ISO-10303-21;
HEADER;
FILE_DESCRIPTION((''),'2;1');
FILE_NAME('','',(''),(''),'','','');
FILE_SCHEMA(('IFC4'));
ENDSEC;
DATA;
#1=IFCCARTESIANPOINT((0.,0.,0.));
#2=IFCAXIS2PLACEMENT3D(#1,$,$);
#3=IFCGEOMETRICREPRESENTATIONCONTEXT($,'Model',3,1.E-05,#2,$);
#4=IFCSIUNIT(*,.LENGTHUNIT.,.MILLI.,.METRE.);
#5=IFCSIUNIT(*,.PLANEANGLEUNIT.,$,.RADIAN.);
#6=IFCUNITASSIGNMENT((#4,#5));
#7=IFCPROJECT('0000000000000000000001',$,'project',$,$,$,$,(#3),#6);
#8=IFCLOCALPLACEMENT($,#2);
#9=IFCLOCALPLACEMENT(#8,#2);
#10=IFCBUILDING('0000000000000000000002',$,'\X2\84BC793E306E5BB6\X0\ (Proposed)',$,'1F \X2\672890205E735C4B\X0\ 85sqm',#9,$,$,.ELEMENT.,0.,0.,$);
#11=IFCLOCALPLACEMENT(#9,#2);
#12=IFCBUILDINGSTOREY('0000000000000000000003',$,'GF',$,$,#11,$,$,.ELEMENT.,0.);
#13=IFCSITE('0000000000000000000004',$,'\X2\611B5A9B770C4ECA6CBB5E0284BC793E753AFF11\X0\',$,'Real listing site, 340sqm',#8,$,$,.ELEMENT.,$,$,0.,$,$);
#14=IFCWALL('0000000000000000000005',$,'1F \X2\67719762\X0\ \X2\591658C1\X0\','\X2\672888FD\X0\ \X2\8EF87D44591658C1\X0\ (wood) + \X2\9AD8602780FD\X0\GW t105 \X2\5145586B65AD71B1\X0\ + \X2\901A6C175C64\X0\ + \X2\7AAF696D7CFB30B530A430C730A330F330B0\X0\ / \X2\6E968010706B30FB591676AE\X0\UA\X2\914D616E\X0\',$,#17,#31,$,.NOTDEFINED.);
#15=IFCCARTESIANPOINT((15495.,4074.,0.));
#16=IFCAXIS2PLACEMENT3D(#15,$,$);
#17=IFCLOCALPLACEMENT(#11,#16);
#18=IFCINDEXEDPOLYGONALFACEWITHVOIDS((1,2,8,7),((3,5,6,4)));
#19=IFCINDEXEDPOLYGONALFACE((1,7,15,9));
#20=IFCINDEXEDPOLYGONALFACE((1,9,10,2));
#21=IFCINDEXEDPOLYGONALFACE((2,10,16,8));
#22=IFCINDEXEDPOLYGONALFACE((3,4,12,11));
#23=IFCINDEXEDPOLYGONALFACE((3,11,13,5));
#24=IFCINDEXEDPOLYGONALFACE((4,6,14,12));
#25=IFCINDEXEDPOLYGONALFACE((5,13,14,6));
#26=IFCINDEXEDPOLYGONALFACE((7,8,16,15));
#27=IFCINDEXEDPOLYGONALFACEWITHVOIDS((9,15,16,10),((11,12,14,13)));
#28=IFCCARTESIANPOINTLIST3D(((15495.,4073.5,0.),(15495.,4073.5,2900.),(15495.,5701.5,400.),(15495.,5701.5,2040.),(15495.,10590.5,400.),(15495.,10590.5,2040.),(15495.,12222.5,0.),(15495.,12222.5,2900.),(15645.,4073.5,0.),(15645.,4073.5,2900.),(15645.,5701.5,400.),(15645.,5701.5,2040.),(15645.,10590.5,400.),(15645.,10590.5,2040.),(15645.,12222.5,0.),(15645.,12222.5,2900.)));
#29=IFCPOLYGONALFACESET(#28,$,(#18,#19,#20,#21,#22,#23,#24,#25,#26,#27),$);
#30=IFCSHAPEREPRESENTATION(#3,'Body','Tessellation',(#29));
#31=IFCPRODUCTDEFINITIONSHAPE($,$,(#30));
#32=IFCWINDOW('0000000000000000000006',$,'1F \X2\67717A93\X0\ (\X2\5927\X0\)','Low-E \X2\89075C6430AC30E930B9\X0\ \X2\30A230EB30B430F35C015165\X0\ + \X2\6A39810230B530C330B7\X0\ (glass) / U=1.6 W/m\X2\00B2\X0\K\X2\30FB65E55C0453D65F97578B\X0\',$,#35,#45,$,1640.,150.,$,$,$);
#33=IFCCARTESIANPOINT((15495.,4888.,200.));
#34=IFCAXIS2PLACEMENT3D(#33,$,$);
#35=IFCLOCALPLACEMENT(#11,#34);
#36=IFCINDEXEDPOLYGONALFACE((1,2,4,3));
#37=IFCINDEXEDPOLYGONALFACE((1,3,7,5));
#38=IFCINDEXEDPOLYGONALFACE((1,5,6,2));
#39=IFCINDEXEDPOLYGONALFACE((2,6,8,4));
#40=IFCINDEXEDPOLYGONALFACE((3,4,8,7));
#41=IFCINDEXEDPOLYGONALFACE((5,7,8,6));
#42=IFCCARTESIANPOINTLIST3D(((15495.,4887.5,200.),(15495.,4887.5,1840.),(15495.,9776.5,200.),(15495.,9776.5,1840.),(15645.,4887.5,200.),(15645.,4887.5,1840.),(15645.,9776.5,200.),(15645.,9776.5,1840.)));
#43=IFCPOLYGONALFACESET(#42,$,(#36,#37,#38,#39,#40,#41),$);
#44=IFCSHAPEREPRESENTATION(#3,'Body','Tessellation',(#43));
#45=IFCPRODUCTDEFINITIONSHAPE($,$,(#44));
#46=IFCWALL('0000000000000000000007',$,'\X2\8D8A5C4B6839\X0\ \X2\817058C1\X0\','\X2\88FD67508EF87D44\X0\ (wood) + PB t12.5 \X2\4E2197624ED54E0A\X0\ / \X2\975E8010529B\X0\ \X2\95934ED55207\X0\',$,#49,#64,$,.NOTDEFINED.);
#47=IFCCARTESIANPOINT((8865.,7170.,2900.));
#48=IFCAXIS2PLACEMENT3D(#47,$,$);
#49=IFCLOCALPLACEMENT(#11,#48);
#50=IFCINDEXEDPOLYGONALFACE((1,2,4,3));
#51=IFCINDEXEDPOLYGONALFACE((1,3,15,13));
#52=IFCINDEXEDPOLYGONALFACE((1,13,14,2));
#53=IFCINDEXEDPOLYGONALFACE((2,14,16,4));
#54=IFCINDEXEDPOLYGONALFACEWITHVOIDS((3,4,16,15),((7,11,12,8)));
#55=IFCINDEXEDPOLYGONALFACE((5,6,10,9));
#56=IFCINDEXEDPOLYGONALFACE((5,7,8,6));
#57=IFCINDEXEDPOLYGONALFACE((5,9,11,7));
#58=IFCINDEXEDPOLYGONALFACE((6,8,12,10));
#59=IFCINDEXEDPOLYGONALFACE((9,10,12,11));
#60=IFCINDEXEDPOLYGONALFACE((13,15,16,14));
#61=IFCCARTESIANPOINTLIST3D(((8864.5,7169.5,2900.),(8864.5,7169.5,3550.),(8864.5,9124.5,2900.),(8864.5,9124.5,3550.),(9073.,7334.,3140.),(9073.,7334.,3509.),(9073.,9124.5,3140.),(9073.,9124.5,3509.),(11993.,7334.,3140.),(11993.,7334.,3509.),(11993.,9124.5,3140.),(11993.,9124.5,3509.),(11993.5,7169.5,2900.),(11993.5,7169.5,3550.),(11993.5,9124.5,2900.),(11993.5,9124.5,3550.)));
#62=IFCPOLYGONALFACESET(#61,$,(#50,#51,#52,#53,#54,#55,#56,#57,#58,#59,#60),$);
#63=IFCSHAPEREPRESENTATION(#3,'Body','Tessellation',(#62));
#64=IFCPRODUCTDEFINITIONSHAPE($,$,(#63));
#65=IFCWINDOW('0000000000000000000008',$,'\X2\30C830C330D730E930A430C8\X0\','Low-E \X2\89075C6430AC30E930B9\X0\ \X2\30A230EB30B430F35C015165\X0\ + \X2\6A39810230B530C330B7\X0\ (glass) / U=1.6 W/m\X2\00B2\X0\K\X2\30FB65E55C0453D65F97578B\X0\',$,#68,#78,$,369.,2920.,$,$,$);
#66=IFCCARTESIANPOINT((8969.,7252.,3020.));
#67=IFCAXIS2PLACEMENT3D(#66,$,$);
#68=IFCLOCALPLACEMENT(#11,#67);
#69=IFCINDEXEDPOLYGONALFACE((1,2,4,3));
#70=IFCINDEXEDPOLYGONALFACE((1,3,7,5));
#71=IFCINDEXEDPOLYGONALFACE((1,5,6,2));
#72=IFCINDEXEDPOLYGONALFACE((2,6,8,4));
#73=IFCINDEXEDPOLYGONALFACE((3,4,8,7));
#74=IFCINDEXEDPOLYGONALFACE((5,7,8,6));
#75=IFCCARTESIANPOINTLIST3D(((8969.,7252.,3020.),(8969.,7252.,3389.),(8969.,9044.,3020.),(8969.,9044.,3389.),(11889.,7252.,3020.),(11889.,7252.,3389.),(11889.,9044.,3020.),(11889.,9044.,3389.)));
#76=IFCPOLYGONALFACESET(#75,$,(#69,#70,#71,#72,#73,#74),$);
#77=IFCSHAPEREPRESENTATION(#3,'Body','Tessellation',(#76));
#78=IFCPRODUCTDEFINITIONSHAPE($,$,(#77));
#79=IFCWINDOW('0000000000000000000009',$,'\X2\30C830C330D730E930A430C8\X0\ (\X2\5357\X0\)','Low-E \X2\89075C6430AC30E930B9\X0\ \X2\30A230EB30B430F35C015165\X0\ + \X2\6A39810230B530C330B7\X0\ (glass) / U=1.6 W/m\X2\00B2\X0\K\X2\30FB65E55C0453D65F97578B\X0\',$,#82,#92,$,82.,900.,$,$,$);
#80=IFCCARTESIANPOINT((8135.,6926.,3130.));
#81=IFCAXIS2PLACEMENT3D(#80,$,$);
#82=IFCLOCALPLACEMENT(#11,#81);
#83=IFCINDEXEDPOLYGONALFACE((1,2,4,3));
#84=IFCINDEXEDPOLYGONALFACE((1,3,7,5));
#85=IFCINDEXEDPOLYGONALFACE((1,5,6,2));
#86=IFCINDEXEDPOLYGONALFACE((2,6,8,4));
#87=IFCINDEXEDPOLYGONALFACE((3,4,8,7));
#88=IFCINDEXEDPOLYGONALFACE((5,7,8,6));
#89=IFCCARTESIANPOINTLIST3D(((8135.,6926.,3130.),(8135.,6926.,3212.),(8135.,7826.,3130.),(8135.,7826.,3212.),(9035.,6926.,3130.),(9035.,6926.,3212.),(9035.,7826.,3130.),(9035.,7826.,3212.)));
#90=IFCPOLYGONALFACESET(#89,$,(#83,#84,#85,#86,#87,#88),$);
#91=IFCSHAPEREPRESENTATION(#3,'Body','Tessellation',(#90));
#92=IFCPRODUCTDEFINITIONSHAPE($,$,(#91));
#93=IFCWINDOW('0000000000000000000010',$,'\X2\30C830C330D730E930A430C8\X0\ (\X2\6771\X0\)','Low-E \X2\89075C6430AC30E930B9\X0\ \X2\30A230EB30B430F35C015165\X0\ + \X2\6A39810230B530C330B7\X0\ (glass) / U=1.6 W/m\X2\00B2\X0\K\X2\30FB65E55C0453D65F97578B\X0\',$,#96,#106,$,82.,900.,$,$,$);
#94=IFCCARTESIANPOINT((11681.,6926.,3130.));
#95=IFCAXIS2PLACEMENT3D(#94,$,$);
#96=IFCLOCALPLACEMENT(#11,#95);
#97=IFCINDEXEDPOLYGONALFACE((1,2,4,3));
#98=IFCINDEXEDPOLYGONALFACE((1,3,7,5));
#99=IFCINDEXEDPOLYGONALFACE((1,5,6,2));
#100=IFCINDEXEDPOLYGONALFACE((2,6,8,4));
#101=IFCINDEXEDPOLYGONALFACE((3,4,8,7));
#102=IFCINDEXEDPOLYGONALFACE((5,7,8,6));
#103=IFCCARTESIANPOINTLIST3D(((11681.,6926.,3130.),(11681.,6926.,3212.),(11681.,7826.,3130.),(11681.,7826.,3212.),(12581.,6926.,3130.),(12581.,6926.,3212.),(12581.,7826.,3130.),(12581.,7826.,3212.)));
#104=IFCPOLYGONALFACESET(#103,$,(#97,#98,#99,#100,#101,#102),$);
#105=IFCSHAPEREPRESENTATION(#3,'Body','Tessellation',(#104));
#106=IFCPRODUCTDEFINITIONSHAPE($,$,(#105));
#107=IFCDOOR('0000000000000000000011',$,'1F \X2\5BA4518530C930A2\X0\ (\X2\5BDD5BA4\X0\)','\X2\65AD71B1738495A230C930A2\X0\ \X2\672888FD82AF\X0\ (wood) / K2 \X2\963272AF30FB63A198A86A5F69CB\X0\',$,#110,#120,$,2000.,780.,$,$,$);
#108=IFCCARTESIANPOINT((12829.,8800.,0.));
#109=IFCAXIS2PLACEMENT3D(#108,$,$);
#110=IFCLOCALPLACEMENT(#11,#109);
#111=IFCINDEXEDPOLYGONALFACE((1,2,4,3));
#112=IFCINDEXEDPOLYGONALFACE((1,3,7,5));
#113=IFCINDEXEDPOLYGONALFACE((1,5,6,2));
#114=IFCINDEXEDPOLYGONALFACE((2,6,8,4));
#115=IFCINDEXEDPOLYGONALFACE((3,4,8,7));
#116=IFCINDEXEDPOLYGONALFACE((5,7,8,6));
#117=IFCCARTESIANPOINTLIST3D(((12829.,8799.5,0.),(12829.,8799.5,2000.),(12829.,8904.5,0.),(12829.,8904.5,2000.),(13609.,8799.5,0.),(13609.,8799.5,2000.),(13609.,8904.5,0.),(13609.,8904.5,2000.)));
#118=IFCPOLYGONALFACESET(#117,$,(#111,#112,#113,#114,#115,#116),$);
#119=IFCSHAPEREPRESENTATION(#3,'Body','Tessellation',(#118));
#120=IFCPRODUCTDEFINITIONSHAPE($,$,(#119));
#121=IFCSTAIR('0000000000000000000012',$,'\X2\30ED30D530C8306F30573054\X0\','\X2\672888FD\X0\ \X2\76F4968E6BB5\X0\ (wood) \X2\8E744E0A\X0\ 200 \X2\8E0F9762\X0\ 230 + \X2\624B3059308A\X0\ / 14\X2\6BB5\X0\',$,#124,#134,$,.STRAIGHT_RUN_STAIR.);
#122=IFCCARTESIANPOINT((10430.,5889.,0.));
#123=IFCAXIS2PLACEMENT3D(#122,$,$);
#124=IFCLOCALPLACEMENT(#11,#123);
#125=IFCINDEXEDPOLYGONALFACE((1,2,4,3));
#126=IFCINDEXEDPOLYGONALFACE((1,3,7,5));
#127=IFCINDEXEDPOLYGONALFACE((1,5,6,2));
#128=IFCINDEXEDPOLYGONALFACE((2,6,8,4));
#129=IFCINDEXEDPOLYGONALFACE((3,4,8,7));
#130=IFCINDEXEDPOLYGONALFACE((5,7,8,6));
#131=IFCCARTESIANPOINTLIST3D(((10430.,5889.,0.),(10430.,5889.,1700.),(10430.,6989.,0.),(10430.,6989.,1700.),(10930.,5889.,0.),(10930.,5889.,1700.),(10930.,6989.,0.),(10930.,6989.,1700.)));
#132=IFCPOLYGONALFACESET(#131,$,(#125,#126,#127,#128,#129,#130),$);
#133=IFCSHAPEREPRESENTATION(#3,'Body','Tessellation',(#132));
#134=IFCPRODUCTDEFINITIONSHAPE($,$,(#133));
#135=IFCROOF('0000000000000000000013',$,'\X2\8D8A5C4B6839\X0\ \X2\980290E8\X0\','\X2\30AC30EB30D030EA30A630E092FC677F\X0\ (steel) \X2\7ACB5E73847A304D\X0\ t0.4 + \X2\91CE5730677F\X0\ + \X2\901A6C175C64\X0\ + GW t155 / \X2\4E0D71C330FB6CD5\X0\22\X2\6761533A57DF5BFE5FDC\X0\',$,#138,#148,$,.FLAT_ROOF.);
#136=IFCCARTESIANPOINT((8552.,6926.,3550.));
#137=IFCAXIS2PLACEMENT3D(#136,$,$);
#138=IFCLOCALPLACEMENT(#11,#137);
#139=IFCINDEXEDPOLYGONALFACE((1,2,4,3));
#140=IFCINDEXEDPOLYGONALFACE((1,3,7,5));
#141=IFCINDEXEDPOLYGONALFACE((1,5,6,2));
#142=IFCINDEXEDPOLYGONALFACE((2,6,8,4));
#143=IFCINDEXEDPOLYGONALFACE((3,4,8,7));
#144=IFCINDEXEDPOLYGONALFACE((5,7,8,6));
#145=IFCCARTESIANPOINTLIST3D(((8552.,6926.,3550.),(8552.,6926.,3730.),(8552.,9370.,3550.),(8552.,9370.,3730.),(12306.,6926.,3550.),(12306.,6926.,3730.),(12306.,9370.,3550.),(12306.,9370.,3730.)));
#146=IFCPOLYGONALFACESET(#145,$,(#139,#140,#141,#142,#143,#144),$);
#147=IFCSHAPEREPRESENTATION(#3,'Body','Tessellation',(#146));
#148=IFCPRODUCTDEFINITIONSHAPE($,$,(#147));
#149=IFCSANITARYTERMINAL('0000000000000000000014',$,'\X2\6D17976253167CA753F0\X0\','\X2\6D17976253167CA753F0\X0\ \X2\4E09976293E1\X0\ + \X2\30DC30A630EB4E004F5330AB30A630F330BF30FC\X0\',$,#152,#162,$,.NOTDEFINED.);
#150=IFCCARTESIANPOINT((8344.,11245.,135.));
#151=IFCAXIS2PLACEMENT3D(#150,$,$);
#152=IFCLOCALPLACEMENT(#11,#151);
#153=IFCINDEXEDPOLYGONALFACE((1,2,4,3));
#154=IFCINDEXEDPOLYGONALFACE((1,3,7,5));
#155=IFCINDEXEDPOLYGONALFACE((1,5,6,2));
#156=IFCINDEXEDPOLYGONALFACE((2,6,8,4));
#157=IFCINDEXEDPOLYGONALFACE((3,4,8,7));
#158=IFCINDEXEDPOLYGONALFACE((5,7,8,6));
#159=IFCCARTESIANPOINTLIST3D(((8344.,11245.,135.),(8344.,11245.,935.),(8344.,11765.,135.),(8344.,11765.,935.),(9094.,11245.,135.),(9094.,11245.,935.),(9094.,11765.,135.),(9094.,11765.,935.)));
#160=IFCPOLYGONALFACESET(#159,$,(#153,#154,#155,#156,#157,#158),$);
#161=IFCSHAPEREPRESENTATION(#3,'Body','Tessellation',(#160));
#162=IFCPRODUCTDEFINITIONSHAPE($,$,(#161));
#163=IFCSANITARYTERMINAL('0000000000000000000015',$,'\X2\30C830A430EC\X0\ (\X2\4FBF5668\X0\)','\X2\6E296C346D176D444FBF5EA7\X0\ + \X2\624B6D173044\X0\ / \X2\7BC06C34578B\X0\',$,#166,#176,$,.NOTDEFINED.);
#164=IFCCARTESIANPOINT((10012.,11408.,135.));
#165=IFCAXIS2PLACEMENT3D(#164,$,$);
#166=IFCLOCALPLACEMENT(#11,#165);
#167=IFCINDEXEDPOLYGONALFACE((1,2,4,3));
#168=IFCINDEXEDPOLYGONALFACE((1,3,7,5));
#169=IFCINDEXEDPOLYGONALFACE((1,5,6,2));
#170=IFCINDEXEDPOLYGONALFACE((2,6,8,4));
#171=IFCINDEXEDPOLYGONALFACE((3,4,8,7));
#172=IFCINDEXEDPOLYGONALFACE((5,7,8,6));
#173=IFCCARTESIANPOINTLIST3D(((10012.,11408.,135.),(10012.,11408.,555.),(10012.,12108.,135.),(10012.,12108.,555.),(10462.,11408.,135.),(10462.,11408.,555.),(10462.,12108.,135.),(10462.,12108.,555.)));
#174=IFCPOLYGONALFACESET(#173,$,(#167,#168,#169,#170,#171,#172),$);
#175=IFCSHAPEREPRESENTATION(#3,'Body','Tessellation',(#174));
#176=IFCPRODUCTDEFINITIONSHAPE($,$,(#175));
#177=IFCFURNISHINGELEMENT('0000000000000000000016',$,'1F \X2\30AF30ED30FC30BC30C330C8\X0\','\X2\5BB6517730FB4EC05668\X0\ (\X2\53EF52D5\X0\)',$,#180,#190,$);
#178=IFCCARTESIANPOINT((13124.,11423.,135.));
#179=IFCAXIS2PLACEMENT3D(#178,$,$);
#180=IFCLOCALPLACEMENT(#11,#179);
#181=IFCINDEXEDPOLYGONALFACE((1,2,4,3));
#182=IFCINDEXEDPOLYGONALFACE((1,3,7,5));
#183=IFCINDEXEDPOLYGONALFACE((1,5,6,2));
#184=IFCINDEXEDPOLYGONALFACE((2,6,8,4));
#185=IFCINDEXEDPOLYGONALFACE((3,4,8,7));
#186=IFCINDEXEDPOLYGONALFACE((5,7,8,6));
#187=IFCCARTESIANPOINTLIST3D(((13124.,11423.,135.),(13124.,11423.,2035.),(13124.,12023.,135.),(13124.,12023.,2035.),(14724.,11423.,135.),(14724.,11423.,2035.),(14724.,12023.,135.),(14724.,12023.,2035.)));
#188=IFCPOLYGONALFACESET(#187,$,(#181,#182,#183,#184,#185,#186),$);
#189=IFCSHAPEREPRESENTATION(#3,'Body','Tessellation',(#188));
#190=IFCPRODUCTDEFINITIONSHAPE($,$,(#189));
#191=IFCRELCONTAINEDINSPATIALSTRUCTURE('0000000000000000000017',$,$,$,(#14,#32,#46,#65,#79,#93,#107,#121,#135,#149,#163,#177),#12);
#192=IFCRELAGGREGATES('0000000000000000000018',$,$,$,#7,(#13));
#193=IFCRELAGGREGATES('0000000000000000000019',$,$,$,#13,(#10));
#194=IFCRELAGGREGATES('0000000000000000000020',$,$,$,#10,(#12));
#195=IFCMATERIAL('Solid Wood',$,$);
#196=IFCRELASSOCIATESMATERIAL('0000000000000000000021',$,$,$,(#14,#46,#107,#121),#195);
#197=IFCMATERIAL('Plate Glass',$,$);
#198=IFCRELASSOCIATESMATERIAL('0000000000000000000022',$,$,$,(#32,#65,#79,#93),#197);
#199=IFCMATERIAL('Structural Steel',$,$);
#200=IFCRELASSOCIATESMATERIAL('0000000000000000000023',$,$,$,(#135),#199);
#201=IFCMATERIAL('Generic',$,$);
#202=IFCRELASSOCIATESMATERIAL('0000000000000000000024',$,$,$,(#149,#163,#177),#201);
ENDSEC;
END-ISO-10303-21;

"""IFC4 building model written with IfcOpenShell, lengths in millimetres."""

from ifc_helpers import new_model, si_unit, frame, frame_2d, origin, place, context, project, spatial, rectangle, extrude, material, element, fill, save


model = new_model("IFC4")

# Units and contexts
model_context = context("Model", 3, precision=1e-05, world=origin())
ifc_project = project(units=[si_unit("LENGTHUNIT", "METRE", prefix="MILLI"), si_unit("PLANEANGLEUNIT", "RADIAN")], contexts=[model_context])

# Site, building, storey
site_placement = place(None, origin())
site = spatial("IfcSite", under=ifc_project, at=site_placement, Name="愛媛県今治市蒼社町１", ObjectType="Real listing site, 340sqm", CompositionType="ELEMENT", RefElevation=0.0)
building_placement = place(site_placement, origin())
building = spatial("IfcBuilding", under=site, at=building_placement, Name="蒼社の家 (Proposed)", ObjectType="1F 木造平屋 85sqm", CompositionType="ELEMENT", ElevationOfRefHeight=0.0, ElevationOfTerrain=0.0)
storey_placement = place(building_placement, origin())
storey = spatial("IfcBuildingStorey", under=building, at=storey_placement, Name="GF", CompositionType="ELEMENT", Elevation=0.0)

# Wall, opening, window
ifc_material_1 = material(Name="Solid Wood")
wall_1_placement = place(storey_placement, frame((15495.0, 4074.0, 0.0)))
wall_1 = element("IfcWall", 1, at=wall_1_placement, inside=storey, material=ifc_material_1, Name="1F 東面 外壁", Description="木製 軸組外壁 (wood) + 高性能GW t105 充填断熱 + 通気層 + 窯業系サイディング / 準耐火・外皮UA配慮", PredefinedType="NOTDEFINED", context=model_context, shape_type="SweptSolid", body=[
    extrude(rectangle(XDim=150.0, YDim=8149.0, at=frame_2d((75.0, 4074.0))), frame((15495.0, 4074.0, 0.0)), (0.0, 0.0, 1.0), 2900.0),
])
opening_1_placement = place(storey_placement, frame((15495.0, 4888.0, 200.0)))
opening_1 = element("IfcOpeningElement", 2, at=opening_1_placement, cuts=wall_1, PredefinedType="NOTDEFINED", context=model_context, shape_type="SweptSolid", body=[
    extrude(rectangle(XDim=150.0, YDim=4889.0, at=frame_2d((75.0, 2444.0))), frame((15495.0, 4888.0, 200.0)), (0.0, 0.0, 1.0), 1640.0),
])
ifc_material_2 = material(Name="Plate Glass")
window_1_placement = place(storey_placement, frame((15495.0, 4888.0, 200.0)))
window_1 = element("IfcWindow", 3, at=window_1_placement, inside=storey, material=ifc_material_2, Name="1F 東窓 (大)", Description="Low-E 複層ガラス アルゴン封入 + 樹脂サッシ (glass) / U=1.6 W/m²K・日射取得型", OverallHeight=1640.0, OverallWidth=150.0, context=model_context, shape_type="SweptSolid", body=[
    extrude(rectangle(XDim=150.0, YDim=4889.0, at=frame_2d((75.0, 2444.0))), frame((15495.0, 4888.0, 200.0)), (0.0, 0.0, 1.0), 1640.0),
])
fill(opening_1, window_1)

# Wall, openings, windows
wall_2_placement = place(storey_placement, frame((8865.0, 7170.0, 2900.0)))
wall_2 = element("IfcWall", 4, at=wall_2_placement, inside=storey, material=ifc_material_1, Name="越屋根 腰壁", Description="製材軸組 (wood) + PB t12.5 両面仕上 / 非耐力 間仕切", PredefinedType="NOTDEFINED", context=model_context, shape_type="SweptSolid", body=[
    extrude(rectangle(XDim=3129.0, YDim=1955.0, at=frame_2d((1564.0, 977.0))), frame((8865.0, 7170.0, 2900.0)), (0.0, 0.0, 1.0), 650.0),
])
opening_2_placement = place(storey_placement, frame((8969.0, 7252.0, 3020.0)))
opening_2 = element("IfcOpeningElement", 5, at=opening_2_placement, cuts=wall_2, PredefinedType="NOTDEFINED", context=model_context, shape_type="SweptSolid", body=[
    extrude(rectangle(XDim=2920.0, YDim=1792.0, at=frame_2d((1460.0, 896.0))), frame((8969.0, 7252.0, 3020.0)), (0.0, 0.0, 1.0), 369.0),
])
opening_3_placement = place(storey_placement, frame((8135.0, 6926.0, 3130.0)))
opening_3 = element("IfcOpeningElement", 6, at=opening_3_placement, cuts=wall_2, PredefinedType="NOTDEFINED", context=model_context, shape_type="SweptSolid", body=[
    extrude(rectangle(XDim=900.0, YDim=900.0, at=frame_2d((450.0, 450.0))), frame((8135.0, 6926.0, 3130.0)), (0.0, 0.0, 1.0), 82.0),
])
opening_4_placement = place(storey_placement, frame((11681.0, 6926.0, 3130.0)))
opening_4 = element("IfcOpeningElement", 7, at=opening_4_placement, cuts=wall_2, PredefinedType="NOTDEFINED", context=model_context, shape_type="SweptSolid", body=[
    extrude(rectangle(XDim=900.0, YDim=900.0, at=frame_2d((450.0, 450.0))), frame((11681.0, 6926.0, 3130.0)), (0.0, 0.0, 1.0), 82.0),
])
window_2_placement = place(storey_placement, frame((8969.0, 7252.0, 3020.0)))
window_2 = element("IfcWindow", 8, at=window_2_placement, inside=storey, material=ifc_material_2, Name="トップライト", Description="Low-E 複層ガラス アルゴン封入 + 樹脂サッシ (glass) / U=1.6 W/m²K・日射取得型", OverallHeight=369.0, OverallWidth=2920.0, context=model_context, shape_type="SweptSolid", body=[
    extrude(rectangle(XDim=2920.0, YDim=1792.0, at=frame_2d((1460.0, 896.0))), frame((8969.0, 7252.0, 3020.0)), (0.0, 0.0, 1.0), 369.0),
])
fill(opening_2, window_2)
window_3_placement = place(storey_placement, frame((8135.0, 6926.0, 3130.0)))
window_3 = element("IfcWindow", 9, at=window_3_placement, inside=storey, material=ifc_material_2, Name="トップライト (南)", Description="Low-E 複層ガラス アルゴン封入 + 樹脂サッシ (glass) / U=1.6 W/m²K・日射取得型", OverallHeight=82.0, OverallWidth=900.0, context=model_context, shape_type="SweptSolid", body=[
    extrude(rectangle(XDim=900.0, YDim=900.0, at=frame_2d((450.0, 450.0))), frame((8135.0, 6926.0, 3130.0)), (0.0, 0.0, 1.0), 82.0),
])
fill(opening_3, window_3)
window_4_placement = place(storey_placement, frame((11681.0, 6926.0, 3130.0)))
window_4 = element("IfcWindow", 10, at=window_4_placement, inside=storey, material=ifc_material_2, Name="トップライト (東)", Description="Low-E 複層ガラス アルゴン封入 + 樹脂サッシ (glass) / U=1.6 W/m²K・日射取得型", OverallHeight=82.0, OverallWidth=900.0, context=model_context, shape_type="SweptSolid", body=[
    extrude(rectangle(XDim=900.0, YDim=900.0, at=frame_2d((450.0, 450.0))), frame((11681.0, 6926.0, 3130.0)), (0.0, 0.0, 1.0), 82.0),
])
fill(opening_4, window_4)

# Door
door_placement = place(storey_placement, frame((12829.0, 8800.0, 0.0)))
element("IfcDoor", 11, at=door_placement, inside=storey, material=ifc_material_1, Name="1F 室内ドア (寝室)", Description="断熱玄関ドア 木製芯 (wood) / K2 防犯・採風機構", OverallHeight=2000.0, OverallWidth=780.0, context=model_context, shape_type="SweptSolid", body=[
    extrude(rectangle(XDim=780.0, YDim=105.0, at=frame_2d((390.0, 52.0))), frame((12829.0, 8800.0, 0.0)), (0.0, 0.0, 1.0), 2000.0),
])

# Stair
stair_placement = place(storey_placement, frame((10430.0, 5889.0, 0.0)))
element("IfcStair", 12, at=stair_placement, inside=storey, material=ifc_material_1, Name="ロフトはしご", Description="木製 直階段 (wood) 蹴上 200 踏面 230 + 手すり / 14段", PredefinedType="STRAIGHT_RUN_STAIR", context=model_context, shape_type="SweptSolid", body=[
    extrude(rectangle(XDim=500.0, YDim=1100.0, at=frame_2d((250.0, 550.0))), frame((10430.0, 5889.0, 0.0)), (0.0, 0.0, 1.0), 1700.0),
])

# Roof
ifc_material_3 = material(Name="Structural Steel")
roof_placement = place(storey_placement, frame((8552.0, 6926.0, 3550.0)))
element("IfcRoof", 13, at=roof_placement, inside=storey, material=ifc_material_3, Name="越屋根 頂部", Description="ガルバリウム鋼板 (steel) 立平葺き t0.4 + 野地板 + 通気層 + GW t155 / 不燃・法22条区域対応", PredefinedType="FLAT_ROOF", context=model_context, shape_type="SweptSolid", body=[
    extrude(rectangle(XDim=3754.0, YDim=2444.0, at=frame_2d((1877.0, 1222.0))), frame((8552.0, 6926.0, 3550.0)), (0.0, 0.0, 1.0), 180.0),
])

# Sanitary terminals
ifc_material_4 = material(Name="Generic")
sanitary_terminal_1_placement = place(storey_placement, frame((8344.0, 11245.0, 135.0)))
element("IfcSanitaryTerminal", 14, at=sanitary_terminal_1_placement, inside=storey, material=ifc_material_4, Name="洗面化粧台", Description="洗面化粧台 三面鏡 + ボウル一体カウンター", PredefinedType="NOTDEFINED", context=model_context, shape_type="SweptSolid", body=[
    extrude(rectangle(XDim=750.0, YDim=520.0, at=frame_2d((375.0, 260.0))), frame((8344.0, 11245.0, 135.0)), (0.0, 0.0, 1.0), 800.0),
])
sanitary_terminal_2_placement = place(storey_placement, frame((10012.0, 11408.0, 135.0)))
element("IfcSanitaryTerminal", 15, at=sanitary_terminal_2_placement, inside=storey, material=ifc_material_4, Name="トイレ (便器)", Description="温水洗浄便座 + 手洗い / 節水型", PredefinedType="NOTDEFINED", context=model_context, shape_type="SweptSolid", body=[
    extrude(rectangle(XDim=450.0, YDim=700.0, at=frame_2d((225.0, 350.0))), frame((10012.0, 11408.0, 135.0)), (0.0, 0.0, 1.0), 420.0),
])

# Furnishing element
furnishing_1_placement = place(storey_placement, frame((13124.0, 11423.0, 135.0)))
element("IfcFurnishingElement", 16, at=furnishing_1_placement, inside=storey, material=ifc_material_4, Name="1F クローゼット", Description="家具・什器 (可動)", context=model_context, shape_type="SweptSolid", body=[
    extrude(rectangle(XDim=1600.0, YDim=600.0, at=frame_2d((800.0, 300.0))), frame((13124.0, 11423.0, 135.0)), (0.0, 0.0, 1.0), 1900.0),
])

save(model, "model.ifc")
